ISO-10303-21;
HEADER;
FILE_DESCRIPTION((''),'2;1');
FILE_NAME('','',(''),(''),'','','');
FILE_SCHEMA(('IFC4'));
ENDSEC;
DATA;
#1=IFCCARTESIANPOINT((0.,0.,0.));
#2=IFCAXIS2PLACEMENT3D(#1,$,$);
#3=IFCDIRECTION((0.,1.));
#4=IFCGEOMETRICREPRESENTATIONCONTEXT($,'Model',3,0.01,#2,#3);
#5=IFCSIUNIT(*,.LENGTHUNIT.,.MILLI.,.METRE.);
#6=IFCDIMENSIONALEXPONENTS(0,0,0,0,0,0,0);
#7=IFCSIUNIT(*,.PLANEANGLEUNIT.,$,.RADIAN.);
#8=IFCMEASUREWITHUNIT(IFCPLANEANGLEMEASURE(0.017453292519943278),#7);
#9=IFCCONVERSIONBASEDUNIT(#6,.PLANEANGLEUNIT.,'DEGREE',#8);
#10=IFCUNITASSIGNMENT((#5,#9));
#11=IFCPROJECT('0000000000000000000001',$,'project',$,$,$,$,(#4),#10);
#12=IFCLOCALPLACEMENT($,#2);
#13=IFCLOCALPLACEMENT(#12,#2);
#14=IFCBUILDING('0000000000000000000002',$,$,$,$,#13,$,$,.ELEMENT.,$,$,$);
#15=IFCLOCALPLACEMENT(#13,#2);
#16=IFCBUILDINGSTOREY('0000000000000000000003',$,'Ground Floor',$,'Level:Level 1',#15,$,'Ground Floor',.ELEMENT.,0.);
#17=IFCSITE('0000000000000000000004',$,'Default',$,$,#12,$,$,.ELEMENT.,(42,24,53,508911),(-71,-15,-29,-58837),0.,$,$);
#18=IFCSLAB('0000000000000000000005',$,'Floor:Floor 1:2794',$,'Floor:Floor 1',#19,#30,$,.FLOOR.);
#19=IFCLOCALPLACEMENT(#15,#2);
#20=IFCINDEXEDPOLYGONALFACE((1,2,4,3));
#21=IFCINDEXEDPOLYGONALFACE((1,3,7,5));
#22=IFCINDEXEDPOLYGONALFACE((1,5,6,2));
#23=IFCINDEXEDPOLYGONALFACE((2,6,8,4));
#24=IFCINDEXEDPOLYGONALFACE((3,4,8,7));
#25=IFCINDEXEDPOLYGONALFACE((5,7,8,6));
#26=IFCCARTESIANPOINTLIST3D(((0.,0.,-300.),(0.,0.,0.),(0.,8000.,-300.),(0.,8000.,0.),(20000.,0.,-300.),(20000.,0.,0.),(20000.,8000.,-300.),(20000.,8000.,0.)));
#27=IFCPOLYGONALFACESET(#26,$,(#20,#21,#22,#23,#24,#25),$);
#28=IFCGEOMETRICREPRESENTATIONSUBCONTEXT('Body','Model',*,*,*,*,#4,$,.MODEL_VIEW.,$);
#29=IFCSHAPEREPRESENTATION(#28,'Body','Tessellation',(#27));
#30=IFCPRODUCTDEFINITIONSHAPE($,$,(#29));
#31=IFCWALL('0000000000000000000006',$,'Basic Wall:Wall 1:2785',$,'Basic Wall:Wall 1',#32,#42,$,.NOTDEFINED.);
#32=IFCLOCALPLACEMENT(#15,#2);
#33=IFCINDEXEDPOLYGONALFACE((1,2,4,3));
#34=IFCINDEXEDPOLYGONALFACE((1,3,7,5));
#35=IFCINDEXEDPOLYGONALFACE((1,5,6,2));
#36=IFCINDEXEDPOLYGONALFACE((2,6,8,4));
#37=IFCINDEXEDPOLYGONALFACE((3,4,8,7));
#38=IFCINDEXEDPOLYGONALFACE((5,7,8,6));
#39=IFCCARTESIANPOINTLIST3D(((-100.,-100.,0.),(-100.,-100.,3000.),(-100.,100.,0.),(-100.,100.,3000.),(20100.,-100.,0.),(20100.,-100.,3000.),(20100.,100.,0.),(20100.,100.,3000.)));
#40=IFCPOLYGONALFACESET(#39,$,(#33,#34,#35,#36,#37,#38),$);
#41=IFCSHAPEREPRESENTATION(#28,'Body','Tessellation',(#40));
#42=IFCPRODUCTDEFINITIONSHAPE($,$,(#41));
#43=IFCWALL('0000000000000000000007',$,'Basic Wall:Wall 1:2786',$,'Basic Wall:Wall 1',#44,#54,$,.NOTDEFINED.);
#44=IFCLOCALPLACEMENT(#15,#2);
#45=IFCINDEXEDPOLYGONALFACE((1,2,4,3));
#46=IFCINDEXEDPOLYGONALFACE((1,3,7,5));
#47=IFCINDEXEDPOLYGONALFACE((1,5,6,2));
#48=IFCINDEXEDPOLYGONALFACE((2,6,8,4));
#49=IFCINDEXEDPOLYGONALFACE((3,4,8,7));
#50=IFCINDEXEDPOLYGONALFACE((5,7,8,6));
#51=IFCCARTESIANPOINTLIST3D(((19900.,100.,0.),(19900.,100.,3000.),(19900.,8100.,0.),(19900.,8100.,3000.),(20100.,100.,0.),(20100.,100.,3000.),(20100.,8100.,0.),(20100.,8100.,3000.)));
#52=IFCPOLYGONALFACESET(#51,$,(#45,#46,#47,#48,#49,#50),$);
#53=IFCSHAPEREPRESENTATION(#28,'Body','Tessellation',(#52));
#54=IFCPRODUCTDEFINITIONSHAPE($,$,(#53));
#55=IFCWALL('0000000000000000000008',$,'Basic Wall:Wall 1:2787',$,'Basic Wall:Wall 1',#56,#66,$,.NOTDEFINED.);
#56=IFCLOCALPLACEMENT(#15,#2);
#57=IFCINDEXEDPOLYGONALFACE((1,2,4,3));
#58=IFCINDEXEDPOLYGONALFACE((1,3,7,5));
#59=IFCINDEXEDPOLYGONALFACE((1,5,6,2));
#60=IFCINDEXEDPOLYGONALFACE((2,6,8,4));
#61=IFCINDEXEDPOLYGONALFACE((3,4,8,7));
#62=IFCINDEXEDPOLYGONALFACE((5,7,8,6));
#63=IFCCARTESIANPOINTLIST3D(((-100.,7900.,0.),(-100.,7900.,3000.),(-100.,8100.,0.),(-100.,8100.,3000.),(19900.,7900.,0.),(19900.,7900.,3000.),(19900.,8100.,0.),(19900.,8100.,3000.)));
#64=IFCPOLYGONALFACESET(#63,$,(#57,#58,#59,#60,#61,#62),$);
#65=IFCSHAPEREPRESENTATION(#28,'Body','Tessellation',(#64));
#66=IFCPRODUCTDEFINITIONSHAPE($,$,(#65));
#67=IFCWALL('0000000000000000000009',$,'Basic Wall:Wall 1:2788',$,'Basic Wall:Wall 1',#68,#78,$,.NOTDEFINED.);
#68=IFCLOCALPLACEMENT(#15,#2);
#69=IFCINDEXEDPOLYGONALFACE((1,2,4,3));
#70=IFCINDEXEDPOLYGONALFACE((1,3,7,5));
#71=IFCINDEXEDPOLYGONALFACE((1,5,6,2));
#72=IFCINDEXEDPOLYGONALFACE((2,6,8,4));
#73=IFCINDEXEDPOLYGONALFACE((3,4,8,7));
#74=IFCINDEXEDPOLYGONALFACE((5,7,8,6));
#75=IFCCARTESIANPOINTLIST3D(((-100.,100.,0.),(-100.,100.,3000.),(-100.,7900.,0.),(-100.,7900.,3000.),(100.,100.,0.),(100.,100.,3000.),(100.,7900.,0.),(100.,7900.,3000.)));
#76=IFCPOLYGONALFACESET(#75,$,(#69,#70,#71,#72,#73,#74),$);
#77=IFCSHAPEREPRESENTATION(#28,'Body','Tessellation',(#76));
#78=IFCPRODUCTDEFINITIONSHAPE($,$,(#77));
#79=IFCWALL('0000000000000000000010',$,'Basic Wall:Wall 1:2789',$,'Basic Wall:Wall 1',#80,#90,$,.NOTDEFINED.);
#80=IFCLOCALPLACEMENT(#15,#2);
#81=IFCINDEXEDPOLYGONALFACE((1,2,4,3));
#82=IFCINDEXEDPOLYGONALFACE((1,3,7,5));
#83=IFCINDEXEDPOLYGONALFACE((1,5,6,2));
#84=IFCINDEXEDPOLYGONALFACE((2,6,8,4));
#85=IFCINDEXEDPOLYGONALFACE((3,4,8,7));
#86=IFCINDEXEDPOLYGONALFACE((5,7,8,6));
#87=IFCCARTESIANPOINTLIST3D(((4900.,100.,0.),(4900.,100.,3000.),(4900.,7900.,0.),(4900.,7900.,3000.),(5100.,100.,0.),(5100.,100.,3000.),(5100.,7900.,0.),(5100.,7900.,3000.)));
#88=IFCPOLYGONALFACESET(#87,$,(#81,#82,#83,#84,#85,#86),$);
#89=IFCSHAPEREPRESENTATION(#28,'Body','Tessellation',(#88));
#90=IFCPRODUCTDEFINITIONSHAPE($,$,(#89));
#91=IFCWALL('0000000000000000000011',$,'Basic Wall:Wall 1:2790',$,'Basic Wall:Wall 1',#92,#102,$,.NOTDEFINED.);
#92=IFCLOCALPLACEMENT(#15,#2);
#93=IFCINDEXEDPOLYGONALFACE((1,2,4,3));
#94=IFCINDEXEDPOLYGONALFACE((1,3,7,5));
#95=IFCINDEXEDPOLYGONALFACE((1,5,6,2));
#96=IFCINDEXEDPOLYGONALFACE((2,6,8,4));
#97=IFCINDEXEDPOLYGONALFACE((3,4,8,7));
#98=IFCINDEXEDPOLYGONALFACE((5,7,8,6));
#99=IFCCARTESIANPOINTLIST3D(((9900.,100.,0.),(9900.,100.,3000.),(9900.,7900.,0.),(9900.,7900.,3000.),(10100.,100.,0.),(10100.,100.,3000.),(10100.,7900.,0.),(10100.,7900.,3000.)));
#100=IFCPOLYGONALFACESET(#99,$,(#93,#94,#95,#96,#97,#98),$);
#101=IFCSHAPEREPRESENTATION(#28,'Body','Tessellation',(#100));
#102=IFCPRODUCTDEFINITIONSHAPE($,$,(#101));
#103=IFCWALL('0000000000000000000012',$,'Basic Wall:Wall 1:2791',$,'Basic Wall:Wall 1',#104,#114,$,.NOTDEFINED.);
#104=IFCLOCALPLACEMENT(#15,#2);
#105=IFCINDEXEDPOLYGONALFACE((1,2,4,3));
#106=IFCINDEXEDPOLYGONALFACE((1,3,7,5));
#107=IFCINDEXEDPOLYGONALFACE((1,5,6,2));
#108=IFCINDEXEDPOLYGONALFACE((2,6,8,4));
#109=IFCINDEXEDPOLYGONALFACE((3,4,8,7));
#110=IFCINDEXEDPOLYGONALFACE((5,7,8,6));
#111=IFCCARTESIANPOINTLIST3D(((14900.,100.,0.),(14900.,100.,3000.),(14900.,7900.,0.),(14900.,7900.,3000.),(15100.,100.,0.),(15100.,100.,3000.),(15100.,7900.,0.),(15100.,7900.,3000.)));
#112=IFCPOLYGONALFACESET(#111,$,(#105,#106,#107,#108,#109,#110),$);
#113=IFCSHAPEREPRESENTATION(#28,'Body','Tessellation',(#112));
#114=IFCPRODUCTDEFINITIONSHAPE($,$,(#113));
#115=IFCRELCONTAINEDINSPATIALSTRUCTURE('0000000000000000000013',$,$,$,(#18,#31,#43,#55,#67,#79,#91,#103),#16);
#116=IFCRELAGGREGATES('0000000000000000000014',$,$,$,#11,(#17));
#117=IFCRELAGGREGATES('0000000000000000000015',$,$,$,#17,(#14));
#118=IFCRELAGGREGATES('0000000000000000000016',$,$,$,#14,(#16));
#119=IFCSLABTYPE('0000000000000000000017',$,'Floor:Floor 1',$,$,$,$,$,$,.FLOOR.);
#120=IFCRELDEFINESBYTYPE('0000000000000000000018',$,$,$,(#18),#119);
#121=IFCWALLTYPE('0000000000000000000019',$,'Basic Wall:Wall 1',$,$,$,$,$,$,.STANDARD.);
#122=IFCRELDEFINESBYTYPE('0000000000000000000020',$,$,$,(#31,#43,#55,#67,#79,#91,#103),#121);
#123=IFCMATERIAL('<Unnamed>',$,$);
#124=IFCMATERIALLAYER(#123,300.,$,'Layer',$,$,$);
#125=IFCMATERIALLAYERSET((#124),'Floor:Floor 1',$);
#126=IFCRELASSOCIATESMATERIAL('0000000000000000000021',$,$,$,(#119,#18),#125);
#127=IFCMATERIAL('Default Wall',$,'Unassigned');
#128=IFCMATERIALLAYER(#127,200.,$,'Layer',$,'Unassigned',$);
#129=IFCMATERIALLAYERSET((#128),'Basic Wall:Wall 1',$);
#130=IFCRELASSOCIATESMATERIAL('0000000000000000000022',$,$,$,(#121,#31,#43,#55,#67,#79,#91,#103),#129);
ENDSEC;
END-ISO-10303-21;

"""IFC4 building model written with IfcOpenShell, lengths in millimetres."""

from ifc_helpers import new_model, entity, si_unit, converted_unit, direction, frame, frame_2d, origin, origin_2d_with_axis, place, context, subcontext, project, spatial, rectangle, extrude, material, layer, layer_set, layer_usage, type_object, element, save


model = new_model("IFC4")

# Units and contexts
model_context = context("Model", 3, precision=0.01, world=origin(), true_north=direction((0.0, 1.0)))
body_context = subcontext(model_context, "Body", "Model", "MODEL_VIEW")
ifc_project = project(units=[si_unit("LENGTHUNIT", "METRE", prefix="MILLI"), converted_unit("PLANEANGLEUNIT", "DEGREE", entity("IfcPlaneAngleMeasure", 0.017453292519943278), si_unit("PLANEANGLEUNIT", "RADIAN"), dimensions=[0, 0, 0, 0, 0, 0, 0])], contexts=[model_context])

# Site, building, storey
site_placement = place(None, origin())
site = spatial("IfcSite", under=ifc_project, at=site_placement, Name="Default", CompositionType="ELEMENT", RefLatitude=(42, 24, 53, 508911), RefLongitude=(-71, -15, -29, -58837), RefElevation=0.0)
building_placement = place(site_placement, origin())
building = spatial("IfcBuilding", under=site, at=building_placement, CompositionType="ELEMENT")
storey_placement = place(building_placement, origin())
storey = spatial("IfcBuildingStorey", under=building, at=storey_placement, Name="Ground Floor", ObjectType="Level:Level 1", LongName="Ground Floor", CompositionType="ELEMENT", Elevation=0.0)

# Slab
ifc_material_1 = material(Name="<Unnamed>")
ifc_layer_1 = layer(ifc_material_1, 300.0, Name="Layer")
ifc_layer_set_1 = layer_set([ifc_layer_1], Name="Floor:Floor 1")
ifc_layer_usage_1 = layer_usage(ifc_layer_set_1, "AXIS3", "POSITIVE", 0.0)
slab_type = type_object("IfcSlabType", Name="Floor:Floor 1", PredefinedType="FLOOR", material=ifc_layer_set_1)
slab_placement = place(storey_placement, origin())
element("IfcSlab", 1, at=slab_placement, inside=storey, type_object=slab_type, material=ifc_layer_usage_1, Name="Floor:Floor 1:2794", ObjectType="Floor:Floor 1", PredefinedType="FLOOR", context=body_context, shape_type="SweptSolid", body=[
    extrude(rectangle(XDim=8000.0, YDim=20000.0, at=origin_2d_with_axis()), frame((10000.0, 4000.0, 0.0), z_axis=(0.0, 0.0, -1.0), x_axis=(0.0, 1.0, 0.0)), (0.0, 0.0, 1.0), 300.0),
])

# Walls
ifc_material_2 = material(Name="Default Wall", Category="Unassigned")
ifc_layer_2 = layer(ifc_material_2, 200.0, Name="Layer", Category="Unassigned")
ifc_layer_set_2 = layer_set([ifc_layer_2], Name="Basic Wall:Wall 1")
ifc_layer_usage_2 = layer_usage(ifc_layer_set_2, "AXIS2", "NEGATIVE", 100.0)
wall_type = type_object("IfcWallType", Name="Basic Wall:Wall 1", PredefinedType="STANDARD", material=ifc_layer_set_2)
wall_1_placement = place(storey_placement, frame((-100.0, 0.0, 0.0)))
element("IfcWall", 2, at=wall_1_placement, inside=storey, type_object=wall_type, material=ifc_layer_usage_2, Name="Basic Wall:Wall 1:2785", ObjectType="Basic Wall:Wall 1", PredefinedType="NOTDEFINED", context=body_context, shape_type="SweptSolid", body=[
    extrude(rectangle(XDim=20200.0, YDim=200.0, at=frame_2d((10100.0, 0.0), x_axis=(-1.0, 0.0))), origin(), (0.0, 0.0, 1.0), 3000.0),
])
ifc_layer_usage_3 = layer_usage(ifc_layer_set_2, "AXIS2", "NEGATIVE", 100.0)
wall_2_placement = place(storey_placement, frame((20000.0, 100.0, 0.0), z_axis=(0.0, 0.0, 1.0), x_axis=(0.0, 1.0, 0.0)))
element("IfcWall", 3, at=wall_2_placement, inside=storey, type_object=wall_type, material=ifc_layer_usage_3, Name="Basic Wall:Wall 1:2786", ObjectType="Basic Wall:Wall 1", PredefinedType="NOTDEFINED", context=body_context, shape_type="SweptSolid", body=[
    extrude(rectangle(XDim=8000.0, YDim=200.0, at=frame_2d((4000.0, 0.0), x_axis=(-1.0, 0.0))), origin(), (0.0, 0.0, 1.0), 3000.0),
])
ifc_layer_usage_4 = layer_usage(ifc_layer_set_2, "AXIS2", "NEGATIVE", 100.0)
wall_3_placement = place(storey_placement, frame((19900.0, 8000.0, 0.0), z_axis=(0.0, 0.0, 1.0), x_axis=(-1.0, 0.0, 0.0)))
element("IfcWall", 4, at=wall_3_placement, inside=storey, type_object=wall_type, material=ifc_layer_usage_4, Name="Basic Wall:Wall 1:2787", ObjectType="Basic Wall:Wall 1", PredefinedType="NOTDEFINED", context=body_context, shape_type="SweptSolid", body=[
    extrude(rectangle(XDim=20000.0, YDim=200.0, at=frame_2d((10000.0, 0.0), x_axis=(-1.0, 0.0))), origin(), (0.0, 0.0, 1.0), 3000.0),
])
ifc_layer_usage_5 = layer_usage(ifc_layer_set_2, "AXIS2", "NEGATIVE", 100.0)
wall_4_placement = place(storey_placement, frame((0.0, 7900.0, 0.0), z_axis=(0.0, 0.0, 1.0), x_axis=(0.0, -1.0, 0.0)))
element("IfcWall", 5, at=wall_4_placement, inside=storey, type_object=wall_type, material=ifc_layer_usage_5, Name="Basic Wall:Wall 1:2788", ObjectType="Basic Wall:Wall 1", PredefinedType="NOTDEFINED", context=body_context, shape_type="SweptSolid", body=[
    extrude(rectangle(XDim=7800.0, YDim=200.0, at=frame_2d((3900.0, 0.0), x_axis=(-1.0, 0.0))), origin(), (0.0, 0.0, 1.0), 3000.0),
])
ifc_layer_usage_6 = layer_usage(ifc_layer_set_2, "AXIS2", "NEGATIVE", 100.0)
wall_5_placement = place(storey_placement, frame((5000.0, 100.0, 0.0), z_axis=(0.0, 0.0, 1.0), x_axis=(0.0, 1.0, 0.0)))
element("IfcWall", 6, at=wall_5_placement, inside=storey, type_object=wall_type, material=ifc_layer_usage_6, Name="Basic Wall:Wall 1:2789", ObjectType="Basic Wall:Wall 1", PredefinedType="NOTDEFINED", context=body_context, shape_type="SweptSolid", body=[
    extrude(rectangle(XDim=7800.0, YDim=200.0, at=frame_2d((3900.0, 0.0), x_axis=(-1.0, 0.0))), origin(), (0.0, 0.0, 1.0), 3000.0),
])
ifc_layer_usage_7 = layer_usage(ifc_layer_set_2, "AXIS2", "NEGATIVE", 100.0)
wall_6_placement = place(storey_placement, frame((10000.0, 100.0, 0.0), z_axis=(0.0, 0.0, 1.0), x_axis=(0.0, 1.0, 0.0)))
element("IfcWall", 7, at=wall_6_placement, inside=storey, type_object=wall_type, material=ifc_layer_usage_7, Name="Basic Wall:Wall 1:2790", ObjectType="Basic Wall:Wall 1", PredefinedType="NOTDEFINED", context=body_context, shape_type="SweptSolid", body=[
    extrude(rectangle(XDim=7800.0, YDim=200.0, at=frame_2d((3900.0, 0.0), x_axis=(-1.0, 0.0))), origin(), (0.0, 0.0, 1.0), 3000.0),
])
ifc_layer_usage_8 = layer_usage(ifc_layer_set_2, "AXIS2", "NEGATIVE", 100.0)
wall_7_placement = place(storey_placement, frame((15000.0, 100.0, 0.0), z_axis=(0.0, 0.0, 1.0), x_axis=(0.0, 1.0, 0.0)))
element("IfcWall", 8, at=wall_7_placement, inside=storey, type_object=wall_type, material=ifc_layer_usage_8, Name="Basic Wall:Wall 1:2791", ObjectType="Basic Wall:Wall 1", PredefinedType="NOTDEFINED", context=body_context, shape_type="SweptSolid", body=[
    extrude(rectangle(XDim=7800.0, YDim=200.0, at=frame_2d((3900.0, 0.0), x_axis=(-1.0, 0.0))), origin(), (0.0, 0.0, 1.0), 3000.0),
])

save(model, "model.ifc")
